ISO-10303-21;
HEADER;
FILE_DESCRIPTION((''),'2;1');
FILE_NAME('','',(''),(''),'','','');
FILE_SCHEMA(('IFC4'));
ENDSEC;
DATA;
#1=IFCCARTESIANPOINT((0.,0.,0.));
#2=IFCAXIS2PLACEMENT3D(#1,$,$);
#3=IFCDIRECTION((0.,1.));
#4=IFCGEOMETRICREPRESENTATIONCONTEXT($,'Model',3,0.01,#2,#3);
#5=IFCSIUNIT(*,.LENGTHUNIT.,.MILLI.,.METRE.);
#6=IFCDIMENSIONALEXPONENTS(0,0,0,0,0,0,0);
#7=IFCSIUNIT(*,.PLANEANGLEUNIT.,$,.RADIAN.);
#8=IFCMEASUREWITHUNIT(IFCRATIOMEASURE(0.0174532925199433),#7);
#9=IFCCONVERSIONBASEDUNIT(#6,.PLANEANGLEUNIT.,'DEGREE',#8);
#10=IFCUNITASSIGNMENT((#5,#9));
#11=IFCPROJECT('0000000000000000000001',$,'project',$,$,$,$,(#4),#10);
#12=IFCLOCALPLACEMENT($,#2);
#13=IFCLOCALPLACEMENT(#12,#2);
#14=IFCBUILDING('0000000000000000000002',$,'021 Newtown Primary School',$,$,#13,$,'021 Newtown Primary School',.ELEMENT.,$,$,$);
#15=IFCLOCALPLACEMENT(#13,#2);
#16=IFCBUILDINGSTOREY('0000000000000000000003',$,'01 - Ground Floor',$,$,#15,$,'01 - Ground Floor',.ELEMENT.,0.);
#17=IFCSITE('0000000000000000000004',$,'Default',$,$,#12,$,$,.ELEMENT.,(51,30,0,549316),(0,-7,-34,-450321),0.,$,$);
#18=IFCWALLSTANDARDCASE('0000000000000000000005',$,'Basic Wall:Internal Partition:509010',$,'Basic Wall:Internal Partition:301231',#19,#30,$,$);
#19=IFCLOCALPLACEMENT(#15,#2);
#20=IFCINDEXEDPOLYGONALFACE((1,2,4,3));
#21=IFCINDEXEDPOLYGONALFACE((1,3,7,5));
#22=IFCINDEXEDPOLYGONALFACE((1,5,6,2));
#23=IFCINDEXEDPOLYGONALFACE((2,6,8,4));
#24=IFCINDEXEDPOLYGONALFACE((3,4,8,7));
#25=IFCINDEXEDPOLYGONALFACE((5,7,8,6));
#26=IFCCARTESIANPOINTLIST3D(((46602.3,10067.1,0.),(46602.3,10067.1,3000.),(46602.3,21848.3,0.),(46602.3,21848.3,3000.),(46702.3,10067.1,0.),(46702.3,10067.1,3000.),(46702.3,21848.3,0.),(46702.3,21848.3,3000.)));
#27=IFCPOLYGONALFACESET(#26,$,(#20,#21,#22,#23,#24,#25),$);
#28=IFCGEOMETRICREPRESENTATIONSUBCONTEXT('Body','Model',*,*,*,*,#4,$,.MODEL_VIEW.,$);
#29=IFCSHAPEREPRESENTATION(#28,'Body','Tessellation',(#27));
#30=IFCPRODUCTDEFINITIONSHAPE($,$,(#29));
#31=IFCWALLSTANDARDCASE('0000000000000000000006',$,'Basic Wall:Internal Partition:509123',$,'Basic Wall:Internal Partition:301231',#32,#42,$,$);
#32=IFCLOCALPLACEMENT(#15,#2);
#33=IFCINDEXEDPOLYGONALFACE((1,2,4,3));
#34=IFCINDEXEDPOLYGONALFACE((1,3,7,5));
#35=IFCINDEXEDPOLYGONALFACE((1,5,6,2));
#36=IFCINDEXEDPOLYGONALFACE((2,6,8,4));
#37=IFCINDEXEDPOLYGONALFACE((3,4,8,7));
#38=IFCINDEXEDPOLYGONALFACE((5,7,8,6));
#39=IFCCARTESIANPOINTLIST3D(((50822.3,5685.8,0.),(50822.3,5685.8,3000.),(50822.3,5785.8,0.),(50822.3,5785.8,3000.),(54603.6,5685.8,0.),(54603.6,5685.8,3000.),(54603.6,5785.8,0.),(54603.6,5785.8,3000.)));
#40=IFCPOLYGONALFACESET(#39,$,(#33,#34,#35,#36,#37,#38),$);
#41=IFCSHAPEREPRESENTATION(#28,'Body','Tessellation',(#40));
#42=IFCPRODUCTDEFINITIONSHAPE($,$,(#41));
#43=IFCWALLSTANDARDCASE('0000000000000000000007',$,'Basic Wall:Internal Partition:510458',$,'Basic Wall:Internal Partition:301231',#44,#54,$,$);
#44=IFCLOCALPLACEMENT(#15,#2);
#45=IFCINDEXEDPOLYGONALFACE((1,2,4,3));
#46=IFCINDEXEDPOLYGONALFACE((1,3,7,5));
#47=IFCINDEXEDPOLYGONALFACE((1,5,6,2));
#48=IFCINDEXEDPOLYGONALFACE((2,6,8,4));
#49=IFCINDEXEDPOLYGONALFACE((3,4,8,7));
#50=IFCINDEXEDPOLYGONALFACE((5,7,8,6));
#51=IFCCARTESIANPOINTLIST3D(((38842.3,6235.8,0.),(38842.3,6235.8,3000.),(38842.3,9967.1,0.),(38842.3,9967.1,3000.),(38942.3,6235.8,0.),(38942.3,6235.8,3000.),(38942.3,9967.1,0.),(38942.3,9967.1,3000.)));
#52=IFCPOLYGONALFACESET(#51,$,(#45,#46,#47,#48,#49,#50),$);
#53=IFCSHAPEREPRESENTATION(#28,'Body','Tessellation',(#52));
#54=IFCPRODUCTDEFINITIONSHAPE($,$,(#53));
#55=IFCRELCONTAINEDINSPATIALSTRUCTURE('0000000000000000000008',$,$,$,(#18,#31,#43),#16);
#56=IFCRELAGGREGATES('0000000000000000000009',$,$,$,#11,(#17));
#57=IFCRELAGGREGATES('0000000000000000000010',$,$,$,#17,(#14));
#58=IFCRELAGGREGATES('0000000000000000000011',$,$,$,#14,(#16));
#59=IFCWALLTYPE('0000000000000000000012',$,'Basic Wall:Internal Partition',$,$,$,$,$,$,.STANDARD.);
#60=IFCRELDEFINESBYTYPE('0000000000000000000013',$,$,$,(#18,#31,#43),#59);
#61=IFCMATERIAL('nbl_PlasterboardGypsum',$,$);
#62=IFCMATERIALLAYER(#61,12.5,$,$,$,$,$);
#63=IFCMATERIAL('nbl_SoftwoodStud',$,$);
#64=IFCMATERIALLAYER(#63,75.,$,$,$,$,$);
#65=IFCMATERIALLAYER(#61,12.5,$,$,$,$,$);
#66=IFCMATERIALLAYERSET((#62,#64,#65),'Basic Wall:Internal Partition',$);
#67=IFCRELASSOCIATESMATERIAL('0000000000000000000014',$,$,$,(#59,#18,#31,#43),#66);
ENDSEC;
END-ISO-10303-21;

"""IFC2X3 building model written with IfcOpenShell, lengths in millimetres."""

from ifc_helpers import new_model, entity, si_unit, converted_unit, direction, frame, frame_2d, origin, place, context, subcontext, project, spatial, rectangle, extrude, material, layer, layer_set, layer_usage, type_object, element, save


model = new_model("IFC2X3")

# Units and contexts
model_context = context("Model", 3, precision=0.01, world=origin(), true_north=direction((0.0, 1.0)))
body_context = subcontext(model_context, "Body", "Model", "MODEL_VIEW")
ifc_project = project(units=[si_unit("LENGTHUNIT", "METRE", prefix="MILLI"), converted_unit("PLANEANGLEUNIT", "DEGREE", entity("IfcRatioMeasure", 0.0174532925199433), si_unit("PLANEANGLEUNIT", "RADIAN"), dimensions=[0, 0, 0, 0, 0, 0, 0])], contexts=[model_context])

# Site, building, storey
site_placement = place(None, origin())
site = spatial("IfcSite", under=ifc_project, at=site_placement, Name="Default", CompositionType="ELEMENT", RefLatitude=(51, 30, 0, 549316), RefLongitude=(0, -7, -34, -450321), RefElevation=0.0)
building_placement = place(site_placement, origin())
building = spatial("IfcBuilding", under=site, at=building_placement, Name="021 Newtown Primary School", LongName="021 Newtown Primary School", CompositionType="ELEMENT")
storey_placement = place(building_placement, origin())
storey = spatial("IfcBuildingStorey", under=building, at=storey_placement, Name="01 - Ground Floor", LongName="01 - Ground Floor", CompositionType="ELEMENT", Elevation=0.0)

# Shared definitions
ifc_material_1 = material(Name="nbl_PlasterboardGypsum")
ifc_layer_1 = layer(ifc_material_1, 12.5)
ifc_material_2 = material(Name="nbl_SoftwoodStud")
ifc_layer_2 = layer(ifc_material_2, 75.0)
ifc_layer_3 = layer(ifc_material_1, 12.5)
ifc_layer_set_1 = layer_set([ifc_layer_1, ifc_layer_2, ifc_layer_3], Name="Basic Wall:Internal Partition")
wall_type_1 = type_object("IfcWallType", Name="Basic Wall:Internal Partition", PredefinedType="STANDARD", material=ifc_layer_set_1)

# Wall
ifc_layer_usage_1 = layer_usage(ifc_layer_set_1, "AXIS2", "NEGATIVE", 50.0)
wall_1_placement = place(storey_placement, frame((46652.3, 10067.1, 0.0), z_axis=(0.0, 0.0, 1.0), x_axis=(0.0, 1.0, 0.0)))
element("IfcWallStandardCase", 1, at=wall_1_placement, inside=storey, type_object=wall_type_1, material=ifc_layer_usage_1, Name="Basic Wall:Internal Partition:509010", ObjectType="Basic Wall:Internal Partition:301231", context=body_context, shape_type="SweptSolid", body=[
    extrude(rectangle(XDim=11781.2, YDim=100.0, at=frame_2d((5890.6, 0.0), x_axis=(-1.0, 0.0))), origin(), (0.0, 0.0, 1.0), 3000.0),
])

# Walls
ifc_layer_usage_2 = layer_usage(ifc_layer_set_1, "AXIS2", "NEGATIVE", 50.0)
wall_2_placement = place(storey_placement, frame((50822.3, 5735.8, 0.0)))
element("IfcWallStandardCase", 2, at=wall_2_placement, inside=storey, type_object=wall_type_1, material=ifc_layer_usage_2, Name="Basic Wall:Internal Partition:509123", ObjectType="Basic Wall:Internal Partition:301231", context=body_context, shape_type="SweptSolid", body=[
    extrude(rectangle(XDim=3781.2, YDim=100.0, at=frame_2d((1890.6, 0.0), x_axis=(-1.0, 0.0))), origin(), (0.0, 0.0, 1.0), 3000.0),
])
ifc_layer_usage_3 = layer_usage(ifc_layer_set_1, "AXIS2", "NEGATIVE", 50.0)
wall_3_placement = place(storey_placement, frame((38892.3, 9967.1, 0.0), z_axis=(0.0, 0.0, 1.0), x_axis=(0.0, -1.0, 0.0)))
element("IfcWallStandardCase", 3, at=wall_3_placement, inside=storey, type_object=wall_type_1, material=ifc_layer_usage_3, Name="Basic Wall:Internal Partition:510458", ObjectType="Basic Wall:Internal Partition:301231", context=body_context, shape_type="SweptSolid", body=[
    extrude(rectangle(XDim=3731.2, YDim=100.0, at=frame_2d((1865.6, 0.0), x_axis=(-1.0, 0.0))), origin(), (0.0, 0.0, 1.0), 3000.0),
])

save(model, "model.ifc")
